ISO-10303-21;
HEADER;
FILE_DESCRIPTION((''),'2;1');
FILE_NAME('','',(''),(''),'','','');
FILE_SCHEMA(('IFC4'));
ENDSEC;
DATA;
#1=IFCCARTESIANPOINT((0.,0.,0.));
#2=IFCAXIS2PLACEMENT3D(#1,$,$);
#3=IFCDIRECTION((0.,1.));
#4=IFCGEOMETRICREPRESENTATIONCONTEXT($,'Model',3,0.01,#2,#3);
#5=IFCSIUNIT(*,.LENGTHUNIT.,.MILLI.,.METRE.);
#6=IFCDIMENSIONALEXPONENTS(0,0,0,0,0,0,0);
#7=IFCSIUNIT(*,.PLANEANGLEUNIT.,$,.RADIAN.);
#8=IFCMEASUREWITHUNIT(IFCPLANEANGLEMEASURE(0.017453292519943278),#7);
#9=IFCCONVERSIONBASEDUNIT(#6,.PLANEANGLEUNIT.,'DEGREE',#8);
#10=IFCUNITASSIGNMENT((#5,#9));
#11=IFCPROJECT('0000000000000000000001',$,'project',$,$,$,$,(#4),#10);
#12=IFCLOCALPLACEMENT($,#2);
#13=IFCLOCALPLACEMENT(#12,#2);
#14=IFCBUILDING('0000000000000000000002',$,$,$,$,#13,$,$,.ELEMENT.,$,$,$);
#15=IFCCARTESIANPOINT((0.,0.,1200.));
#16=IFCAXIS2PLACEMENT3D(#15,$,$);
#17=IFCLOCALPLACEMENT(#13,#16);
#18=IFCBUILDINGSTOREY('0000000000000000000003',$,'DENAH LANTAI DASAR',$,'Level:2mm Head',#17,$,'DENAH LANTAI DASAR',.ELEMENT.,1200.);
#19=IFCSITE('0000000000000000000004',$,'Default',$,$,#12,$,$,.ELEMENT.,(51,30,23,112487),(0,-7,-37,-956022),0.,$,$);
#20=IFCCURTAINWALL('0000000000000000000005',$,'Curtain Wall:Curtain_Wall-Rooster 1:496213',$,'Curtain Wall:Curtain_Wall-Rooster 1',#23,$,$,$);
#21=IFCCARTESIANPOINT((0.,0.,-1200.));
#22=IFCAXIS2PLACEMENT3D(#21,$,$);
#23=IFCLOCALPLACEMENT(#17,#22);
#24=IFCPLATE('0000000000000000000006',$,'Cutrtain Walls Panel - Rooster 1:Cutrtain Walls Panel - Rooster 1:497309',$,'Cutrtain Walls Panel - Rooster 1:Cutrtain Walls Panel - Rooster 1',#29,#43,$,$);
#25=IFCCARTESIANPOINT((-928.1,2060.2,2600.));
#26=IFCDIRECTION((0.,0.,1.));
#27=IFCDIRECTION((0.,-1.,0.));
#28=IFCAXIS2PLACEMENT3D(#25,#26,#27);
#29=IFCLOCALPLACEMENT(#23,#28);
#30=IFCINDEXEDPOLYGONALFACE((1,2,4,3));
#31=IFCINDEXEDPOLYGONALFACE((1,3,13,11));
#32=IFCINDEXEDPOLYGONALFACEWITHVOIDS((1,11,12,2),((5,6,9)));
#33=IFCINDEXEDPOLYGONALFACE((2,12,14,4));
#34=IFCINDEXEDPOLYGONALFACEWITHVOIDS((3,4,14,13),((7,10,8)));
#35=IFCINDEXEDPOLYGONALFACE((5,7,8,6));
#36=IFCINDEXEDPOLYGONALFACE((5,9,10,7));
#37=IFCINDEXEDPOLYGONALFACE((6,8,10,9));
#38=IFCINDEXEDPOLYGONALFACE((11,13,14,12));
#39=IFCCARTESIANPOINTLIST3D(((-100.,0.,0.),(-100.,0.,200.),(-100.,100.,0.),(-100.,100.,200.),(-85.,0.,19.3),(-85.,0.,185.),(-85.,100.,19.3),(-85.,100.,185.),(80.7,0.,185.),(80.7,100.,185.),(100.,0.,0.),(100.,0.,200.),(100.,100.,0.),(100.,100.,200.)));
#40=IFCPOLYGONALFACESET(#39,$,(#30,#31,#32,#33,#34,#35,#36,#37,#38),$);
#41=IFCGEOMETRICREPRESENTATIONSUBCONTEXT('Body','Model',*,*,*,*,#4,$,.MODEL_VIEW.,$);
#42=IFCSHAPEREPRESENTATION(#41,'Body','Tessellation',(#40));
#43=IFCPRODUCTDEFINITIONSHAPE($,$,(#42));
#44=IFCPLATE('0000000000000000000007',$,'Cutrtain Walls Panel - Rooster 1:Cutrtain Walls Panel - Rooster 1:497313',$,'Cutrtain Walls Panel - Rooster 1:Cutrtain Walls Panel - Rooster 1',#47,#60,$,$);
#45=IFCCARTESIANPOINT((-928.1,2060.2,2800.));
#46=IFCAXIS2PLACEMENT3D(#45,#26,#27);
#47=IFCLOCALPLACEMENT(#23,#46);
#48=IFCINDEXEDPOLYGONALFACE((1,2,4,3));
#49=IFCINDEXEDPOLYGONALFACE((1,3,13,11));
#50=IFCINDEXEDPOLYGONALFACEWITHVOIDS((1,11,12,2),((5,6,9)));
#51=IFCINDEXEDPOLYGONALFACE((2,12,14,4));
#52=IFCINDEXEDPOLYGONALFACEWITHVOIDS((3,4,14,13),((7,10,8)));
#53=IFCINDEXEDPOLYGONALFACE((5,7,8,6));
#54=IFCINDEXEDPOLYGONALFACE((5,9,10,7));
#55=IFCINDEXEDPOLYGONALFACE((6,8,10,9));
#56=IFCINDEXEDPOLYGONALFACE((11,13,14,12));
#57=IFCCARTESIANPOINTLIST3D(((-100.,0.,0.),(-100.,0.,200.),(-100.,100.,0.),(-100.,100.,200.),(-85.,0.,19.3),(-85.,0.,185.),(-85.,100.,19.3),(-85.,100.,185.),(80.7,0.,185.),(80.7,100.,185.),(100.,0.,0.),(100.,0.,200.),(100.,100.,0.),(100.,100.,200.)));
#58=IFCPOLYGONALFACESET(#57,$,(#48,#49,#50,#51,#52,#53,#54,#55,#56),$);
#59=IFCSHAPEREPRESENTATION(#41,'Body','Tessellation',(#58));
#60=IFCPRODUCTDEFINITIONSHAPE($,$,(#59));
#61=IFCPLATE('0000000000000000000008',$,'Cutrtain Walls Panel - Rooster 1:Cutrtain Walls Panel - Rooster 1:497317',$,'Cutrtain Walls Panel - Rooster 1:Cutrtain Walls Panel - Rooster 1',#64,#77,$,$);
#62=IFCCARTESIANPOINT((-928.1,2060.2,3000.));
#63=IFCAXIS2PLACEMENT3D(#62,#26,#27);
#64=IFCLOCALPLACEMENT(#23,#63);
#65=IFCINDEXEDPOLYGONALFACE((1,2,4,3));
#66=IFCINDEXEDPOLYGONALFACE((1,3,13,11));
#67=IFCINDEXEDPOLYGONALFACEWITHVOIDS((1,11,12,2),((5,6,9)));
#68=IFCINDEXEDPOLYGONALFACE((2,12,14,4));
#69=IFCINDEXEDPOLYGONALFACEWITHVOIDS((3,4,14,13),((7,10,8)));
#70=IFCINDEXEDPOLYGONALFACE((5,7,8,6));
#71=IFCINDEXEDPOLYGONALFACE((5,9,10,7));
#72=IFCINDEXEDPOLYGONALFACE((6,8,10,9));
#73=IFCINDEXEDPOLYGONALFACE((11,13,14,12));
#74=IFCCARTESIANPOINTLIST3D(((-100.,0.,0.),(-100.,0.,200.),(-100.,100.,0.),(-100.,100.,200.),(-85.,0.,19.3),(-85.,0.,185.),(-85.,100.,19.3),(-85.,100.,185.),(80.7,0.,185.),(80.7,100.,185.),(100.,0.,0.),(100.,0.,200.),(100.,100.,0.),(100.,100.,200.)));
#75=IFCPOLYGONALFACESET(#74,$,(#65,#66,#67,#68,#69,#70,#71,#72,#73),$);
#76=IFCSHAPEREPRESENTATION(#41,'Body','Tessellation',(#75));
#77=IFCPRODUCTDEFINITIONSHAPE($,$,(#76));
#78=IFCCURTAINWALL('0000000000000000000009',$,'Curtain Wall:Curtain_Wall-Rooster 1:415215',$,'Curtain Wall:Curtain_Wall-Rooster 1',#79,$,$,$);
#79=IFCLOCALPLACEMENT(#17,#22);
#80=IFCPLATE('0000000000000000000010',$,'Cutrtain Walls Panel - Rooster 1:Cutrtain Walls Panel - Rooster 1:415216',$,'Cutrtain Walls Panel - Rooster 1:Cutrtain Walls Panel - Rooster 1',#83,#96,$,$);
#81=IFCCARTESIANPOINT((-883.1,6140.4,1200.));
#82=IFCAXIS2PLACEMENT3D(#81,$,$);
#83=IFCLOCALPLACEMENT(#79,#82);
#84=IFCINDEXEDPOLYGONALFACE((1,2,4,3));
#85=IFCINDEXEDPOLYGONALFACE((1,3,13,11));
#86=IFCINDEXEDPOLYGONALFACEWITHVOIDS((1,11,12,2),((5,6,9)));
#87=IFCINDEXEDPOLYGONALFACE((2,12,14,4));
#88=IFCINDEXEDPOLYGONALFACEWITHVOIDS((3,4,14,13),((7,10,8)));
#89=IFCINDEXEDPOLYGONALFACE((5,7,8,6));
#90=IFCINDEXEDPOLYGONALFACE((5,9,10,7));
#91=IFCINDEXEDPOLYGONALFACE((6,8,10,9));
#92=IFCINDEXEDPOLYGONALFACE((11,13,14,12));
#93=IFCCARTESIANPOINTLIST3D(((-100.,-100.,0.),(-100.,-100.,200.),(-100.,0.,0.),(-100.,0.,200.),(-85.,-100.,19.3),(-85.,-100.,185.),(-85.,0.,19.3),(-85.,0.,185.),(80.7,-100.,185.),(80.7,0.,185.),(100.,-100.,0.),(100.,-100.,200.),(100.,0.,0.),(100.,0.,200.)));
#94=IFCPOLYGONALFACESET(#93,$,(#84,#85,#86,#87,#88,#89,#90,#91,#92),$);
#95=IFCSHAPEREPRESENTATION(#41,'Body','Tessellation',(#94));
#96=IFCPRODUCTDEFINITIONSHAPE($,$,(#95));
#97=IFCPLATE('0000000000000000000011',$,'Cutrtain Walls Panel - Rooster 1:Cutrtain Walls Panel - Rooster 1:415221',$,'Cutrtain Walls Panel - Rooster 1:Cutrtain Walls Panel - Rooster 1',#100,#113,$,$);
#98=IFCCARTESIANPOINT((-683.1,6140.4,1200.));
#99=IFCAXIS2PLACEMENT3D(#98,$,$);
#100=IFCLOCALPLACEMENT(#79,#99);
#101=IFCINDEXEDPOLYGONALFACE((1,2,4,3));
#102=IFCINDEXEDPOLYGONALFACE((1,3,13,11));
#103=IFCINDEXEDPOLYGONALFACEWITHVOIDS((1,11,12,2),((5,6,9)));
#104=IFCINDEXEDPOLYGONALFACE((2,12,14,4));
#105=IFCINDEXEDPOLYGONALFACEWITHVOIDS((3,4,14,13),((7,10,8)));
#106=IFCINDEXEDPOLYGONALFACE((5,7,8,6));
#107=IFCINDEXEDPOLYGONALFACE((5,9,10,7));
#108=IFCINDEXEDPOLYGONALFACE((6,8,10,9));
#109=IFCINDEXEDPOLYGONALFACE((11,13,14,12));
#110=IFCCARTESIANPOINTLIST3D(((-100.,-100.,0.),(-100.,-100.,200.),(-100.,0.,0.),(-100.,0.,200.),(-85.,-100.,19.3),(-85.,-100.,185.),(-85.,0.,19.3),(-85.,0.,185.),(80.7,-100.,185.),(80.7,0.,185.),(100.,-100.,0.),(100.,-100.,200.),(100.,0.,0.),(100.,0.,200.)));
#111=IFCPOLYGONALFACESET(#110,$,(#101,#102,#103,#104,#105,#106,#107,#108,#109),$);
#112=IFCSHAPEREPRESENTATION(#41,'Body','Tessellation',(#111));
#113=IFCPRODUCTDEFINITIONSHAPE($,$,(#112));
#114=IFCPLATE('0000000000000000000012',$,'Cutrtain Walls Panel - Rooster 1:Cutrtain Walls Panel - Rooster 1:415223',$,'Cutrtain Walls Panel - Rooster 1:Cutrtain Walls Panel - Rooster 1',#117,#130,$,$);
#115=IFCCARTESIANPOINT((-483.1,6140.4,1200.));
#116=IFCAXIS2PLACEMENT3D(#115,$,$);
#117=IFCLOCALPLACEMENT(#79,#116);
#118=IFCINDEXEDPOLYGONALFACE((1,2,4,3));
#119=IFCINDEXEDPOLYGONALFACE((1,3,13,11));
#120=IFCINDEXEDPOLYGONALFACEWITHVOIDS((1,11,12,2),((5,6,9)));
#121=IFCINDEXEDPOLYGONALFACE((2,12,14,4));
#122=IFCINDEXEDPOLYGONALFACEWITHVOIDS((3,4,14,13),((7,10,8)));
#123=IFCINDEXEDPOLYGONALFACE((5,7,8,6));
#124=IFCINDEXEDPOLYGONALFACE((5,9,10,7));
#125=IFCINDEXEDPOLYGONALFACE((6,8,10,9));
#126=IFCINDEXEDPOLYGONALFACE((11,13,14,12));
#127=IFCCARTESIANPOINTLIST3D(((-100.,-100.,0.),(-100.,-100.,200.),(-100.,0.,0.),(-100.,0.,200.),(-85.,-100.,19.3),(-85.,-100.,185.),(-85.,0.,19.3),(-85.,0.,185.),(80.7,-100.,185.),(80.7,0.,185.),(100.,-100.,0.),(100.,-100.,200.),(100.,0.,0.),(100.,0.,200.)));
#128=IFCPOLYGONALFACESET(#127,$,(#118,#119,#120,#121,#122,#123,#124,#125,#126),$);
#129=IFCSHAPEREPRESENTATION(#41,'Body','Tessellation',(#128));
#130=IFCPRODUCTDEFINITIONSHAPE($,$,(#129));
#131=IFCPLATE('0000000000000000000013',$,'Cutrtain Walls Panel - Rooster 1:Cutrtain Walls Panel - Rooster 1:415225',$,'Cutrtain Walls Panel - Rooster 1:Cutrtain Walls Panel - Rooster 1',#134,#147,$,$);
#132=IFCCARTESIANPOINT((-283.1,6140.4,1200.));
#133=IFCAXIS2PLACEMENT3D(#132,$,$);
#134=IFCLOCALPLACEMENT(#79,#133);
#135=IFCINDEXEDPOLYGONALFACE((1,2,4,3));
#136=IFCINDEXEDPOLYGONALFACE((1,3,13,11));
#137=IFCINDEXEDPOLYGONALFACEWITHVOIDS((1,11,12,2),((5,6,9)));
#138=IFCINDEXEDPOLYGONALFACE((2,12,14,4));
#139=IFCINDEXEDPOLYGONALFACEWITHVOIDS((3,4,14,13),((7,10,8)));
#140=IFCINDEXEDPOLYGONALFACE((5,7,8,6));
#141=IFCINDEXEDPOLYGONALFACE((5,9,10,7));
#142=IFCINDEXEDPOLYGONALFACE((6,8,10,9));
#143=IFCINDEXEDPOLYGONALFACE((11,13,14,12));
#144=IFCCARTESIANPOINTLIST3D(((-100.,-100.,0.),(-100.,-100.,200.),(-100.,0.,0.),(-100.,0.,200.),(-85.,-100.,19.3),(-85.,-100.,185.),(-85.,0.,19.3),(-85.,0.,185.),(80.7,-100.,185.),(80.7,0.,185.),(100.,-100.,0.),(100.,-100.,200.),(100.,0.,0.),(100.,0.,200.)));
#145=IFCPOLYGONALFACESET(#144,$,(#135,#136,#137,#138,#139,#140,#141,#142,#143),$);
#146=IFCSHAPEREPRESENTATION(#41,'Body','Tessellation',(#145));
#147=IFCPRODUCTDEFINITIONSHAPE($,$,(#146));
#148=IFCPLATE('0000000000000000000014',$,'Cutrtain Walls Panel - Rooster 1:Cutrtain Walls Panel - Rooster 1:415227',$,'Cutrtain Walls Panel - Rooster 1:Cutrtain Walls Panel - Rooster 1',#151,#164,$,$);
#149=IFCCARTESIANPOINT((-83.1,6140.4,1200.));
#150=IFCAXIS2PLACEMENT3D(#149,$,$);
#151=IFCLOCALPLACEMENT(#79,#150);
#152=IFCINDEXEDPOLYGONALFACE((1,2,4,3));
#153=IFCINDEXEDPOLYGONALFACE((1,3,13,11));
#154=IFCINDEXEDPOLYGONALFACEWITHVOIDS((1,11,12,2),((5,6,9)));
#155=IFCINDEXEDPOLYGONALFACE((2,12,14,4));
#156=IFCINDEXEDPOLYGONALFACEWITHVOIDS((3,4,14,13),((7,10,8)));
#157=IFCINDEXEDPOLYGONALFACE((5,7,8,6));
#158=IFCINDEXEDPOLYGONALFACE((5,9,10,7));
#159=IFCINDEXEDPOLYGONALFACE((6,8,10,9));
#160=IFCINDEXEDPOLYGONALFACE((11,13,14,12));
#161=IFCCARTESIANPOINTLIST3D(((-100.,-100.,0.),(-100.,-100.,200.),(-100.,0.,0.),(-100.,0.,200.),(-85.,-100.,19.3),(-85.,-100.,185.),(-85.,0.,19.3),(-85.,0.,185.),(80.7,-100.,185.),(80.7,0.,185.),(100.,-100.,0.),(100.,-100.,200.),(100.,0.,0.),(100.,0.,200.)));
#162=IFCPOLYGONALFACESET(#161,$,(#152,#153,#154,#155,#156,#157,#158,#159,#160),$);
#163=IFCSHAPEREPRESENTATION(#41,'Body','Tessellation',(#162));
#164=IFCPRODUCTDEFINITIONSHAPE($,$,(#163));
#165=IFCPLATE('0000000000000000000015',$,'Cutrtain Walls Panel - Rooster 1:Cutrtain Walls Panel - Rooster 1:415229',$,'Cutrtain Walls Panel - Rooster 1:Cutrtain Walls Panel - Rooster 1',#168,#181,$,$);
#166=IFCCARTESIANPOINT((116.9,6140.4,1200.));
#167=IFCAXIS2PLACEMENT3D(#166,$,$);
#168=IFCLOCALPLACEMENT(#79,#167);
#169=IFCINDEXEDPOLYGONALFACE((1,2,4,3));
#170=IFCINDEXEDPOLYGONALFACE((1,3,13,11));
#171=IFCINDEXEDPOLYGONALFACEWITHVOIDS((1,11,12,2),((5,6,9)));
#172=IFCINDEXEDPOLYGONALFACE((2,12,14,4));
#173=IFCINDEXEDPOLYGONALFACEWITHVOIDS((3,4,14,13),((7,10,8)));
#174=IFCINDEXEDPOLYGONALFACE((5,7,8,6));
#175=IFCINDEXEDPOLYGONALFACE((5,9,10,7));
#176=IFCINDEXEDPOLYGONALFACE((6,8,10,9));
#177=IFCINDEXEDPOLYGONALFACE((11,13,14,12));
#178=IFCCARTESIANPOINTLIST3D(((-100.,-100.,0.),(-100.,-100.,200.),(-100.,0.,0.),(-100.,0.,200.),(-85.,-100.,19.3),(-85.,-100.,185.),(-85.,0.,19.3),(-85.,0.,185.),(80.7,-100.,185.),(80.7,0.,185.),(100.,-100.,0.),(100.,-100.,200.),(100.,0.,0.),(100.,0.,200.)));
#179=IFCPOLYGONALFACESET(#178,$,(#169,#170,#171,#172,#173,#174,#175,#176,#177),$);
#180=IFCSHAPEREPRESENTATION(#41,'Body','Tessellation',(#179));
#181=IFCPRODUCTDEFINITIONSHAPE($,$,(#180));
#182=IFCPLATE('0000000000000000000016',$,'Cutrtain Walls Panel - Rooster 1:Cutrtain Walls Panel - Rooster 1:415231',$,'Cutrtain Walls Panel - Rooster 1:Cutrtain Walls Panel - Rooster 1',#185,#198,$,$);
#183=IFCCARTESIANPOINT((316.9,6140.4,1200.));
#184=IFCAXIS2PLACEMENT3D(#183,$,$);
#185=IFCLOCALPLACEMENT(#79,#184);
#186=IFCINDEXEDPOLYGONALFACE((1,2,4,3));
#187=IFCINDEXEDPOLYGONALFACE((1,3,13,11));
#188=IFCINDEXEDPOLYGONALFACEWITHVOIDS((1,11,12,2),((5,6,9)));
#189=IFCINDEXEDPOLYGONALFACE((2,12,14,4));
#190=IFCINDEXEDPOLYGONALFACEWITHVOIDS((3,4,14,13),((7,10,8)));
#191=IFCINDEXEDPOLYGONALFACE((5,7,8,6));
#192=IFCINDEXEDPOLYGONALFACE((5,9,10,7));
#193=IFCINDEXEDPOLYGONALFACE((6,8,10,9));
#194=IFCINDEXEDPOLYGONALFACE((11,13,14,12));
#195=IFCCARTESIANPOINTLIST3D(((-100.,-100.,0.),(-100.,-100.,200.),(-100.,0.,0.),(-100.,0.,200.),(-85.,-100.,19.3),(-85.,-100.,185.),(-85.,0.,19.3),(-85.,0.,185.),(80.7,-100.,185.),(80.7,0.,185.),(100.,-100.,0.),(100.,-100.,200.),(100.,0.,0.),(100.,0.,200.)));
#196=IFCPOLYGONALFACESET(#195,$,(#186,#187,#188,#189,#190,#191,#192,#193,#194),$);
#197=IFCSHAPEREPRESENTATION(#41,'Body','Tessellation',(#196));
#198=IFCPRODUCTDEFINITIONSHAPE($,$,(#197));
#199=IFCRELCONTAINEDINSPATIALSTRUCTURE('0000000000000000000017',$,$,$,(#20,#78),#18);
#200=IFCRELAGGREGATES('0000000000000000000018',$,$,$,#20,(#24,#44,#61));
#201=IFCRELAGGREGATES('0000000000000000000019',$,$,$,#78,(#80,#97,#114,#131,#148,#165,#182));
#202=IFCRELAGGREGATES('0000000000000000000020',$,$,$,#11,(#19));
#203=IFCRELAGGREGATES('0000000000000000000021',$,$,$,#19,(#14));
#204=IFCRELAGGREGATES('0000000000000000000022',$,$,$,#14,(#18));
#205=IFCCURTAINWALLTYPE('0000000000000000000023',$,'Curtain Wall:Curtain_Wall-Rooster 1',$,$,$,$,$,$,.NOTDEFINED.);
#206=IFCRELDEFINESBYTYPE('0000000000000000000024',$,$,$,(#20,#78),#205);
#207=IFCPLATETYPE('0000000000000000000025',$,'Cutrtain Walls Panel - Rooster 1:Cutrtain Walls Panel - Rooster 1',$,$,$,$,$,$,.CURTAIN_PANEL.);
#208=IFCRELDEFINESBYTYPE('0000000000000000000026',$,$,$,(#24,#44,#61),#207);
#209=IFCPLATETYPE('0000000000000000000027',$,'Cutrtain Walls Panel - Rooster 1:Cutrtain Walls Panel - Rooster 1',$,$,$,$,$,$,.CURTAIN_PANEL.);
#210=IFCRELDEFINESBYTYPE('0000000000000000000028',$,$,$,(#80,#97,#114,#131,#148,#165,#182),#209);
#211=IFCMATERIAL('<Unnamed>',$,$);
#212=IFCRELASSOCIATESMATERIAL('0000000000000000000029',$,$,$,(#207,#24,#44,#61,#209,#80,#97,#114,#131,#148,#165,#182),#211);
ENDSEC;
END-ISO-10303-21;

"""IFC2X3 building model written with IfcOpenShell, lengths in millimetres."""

from ifc_helpers import new_model, entity, si_unit, converted_unit, direction, frame, origin, place, context, subcontext, project, spatial, polyline, outline, extrude, source, transform, mapped, material, type_object, type_shapes, element, aggregate, save


model = new_model("IFC2X3")

# Units and contexts
model_context = context("Model", 3, precision=0.01, world=origin(), true_north=direction((0.0, 1.0)))
body_context = subcontext(model_context, "Body", "Model", "MODEL_VIEW")
ifc_project = project(units=[si_unit("LENGTHUNIT", "METRE", prefix="MILLI"), converted_unit("PLANEANGLEUNIT", "DEGREE", entity("IfcPlaneAngleMeasure", 0.017453292519943278), si_unit("PLANEANGLEUNIT", "RADIAN"), dimensions=[0, 0, 0, 0, 0, 0, 0])], contexts=[model_context])

# Site, building, storey
site_placement = place(None, origin())
site = spatial("IfcSite", under=ifc_project, at=site_placement, Name="Default", CompositionType="ELEMENT", RefLatitude=(51, 30, 23, 112487), RefLongitude=(0, -7, -37, -956022), RefElevation=0.0)
building_placement = place(site_placement, origin())
building = spatial("IfcBuilding", under=site, at=building_placement, CompositionType="ELEMENT")
storey_placement = place(building_placement, frame((0.0, 0.0, 1200.0)))
storey = spatial("IfcBuildingStorey", under=building, at=storey_placement, Name="DENAH LANTAI DASAR", ObjectType="Level:2mm Head", LongName="DENAH LANTAI DASAR", CompositionType="ELEMENT", Elevation=1200.0)

# Curtain walls, plates
curtain_wall_type = type_object("IfcCurtainWallType", Name="Curtain Wall:Curtain_Wall-Rooster 1", PredefinedType="NOTDEFINED")
curtain_wall_1_placement = place(storey_placement, frame((0.0, 0.0, -1200.0)))
curtain_wall_1 = element("IfcCurtainWall", 1, at=curtain_wall_1_placement, inside=storey, type_object=curtain_wall_type, Name="Curtain Wall:Curtain_Wall-Rooster 1:496213", ObjectType="Curtain Wall:Curtain_Wall-Rooster 1")
ifc_material_1 = material(Name="<Unnamed>")
plate_type_1 = type_object("IfcPlateType", Name="Cutrtain Walls Panel - Rooster 1:Cutrtain Walls Panel - Rooster 1", PredefinedType="CURTAIN_PANEL", material=ifc_material_1)
shared_shape_1 = source(origin(), body_context, "Body", "SweptSolid", [
    extrude(outline(polyline([(-100.0, -100.0), (100.0, -100.0), (100.0, 100.0), (-100.0, 100.0), (-100.0, -100.0)]), holes=[polyline([(80.7, 85.0), (-85.0, -80.7), (-85.0, 85.0), (80.7, 85.0)])]), frame((0.0, 0.0, 100.0), z_axis=(0.0, 1.0, 0.0), x_axis=(0.0, 0.0, -1.0)), (0.0, 0.0, 1.0), 100.0),
])
type_shapes(plate_type_1, [shared_shape_1])
plate_1_placement = place(curtain_wall_1_placement, frame((-928.1, 2060.2, 2600.0), z_axis=(0.0, 0.0, 1.0), x_axis=(0.0, -1.0, 0.0)))
plate_1 = element("IfcPlate", 2, at=plate_1_placement, type_object=plate_type_1, material=ifc_material_1, Name="Cutrtain Walls Panel - Rooster 1:Cutrtain Walls Panel - Rooster 1:497309", ObjectType="Cutrtain Walls Panel - Rooster 1:Cutrtain Walls Panel - Rooster 1", context=body_context, shape_type="MappedRepresentation", body=[
    mapped(shared_shape_1, transform((0.0, 0.0, 0.0), scale=1.0)),
])
plate_2_placement = place(curtain_wall_1_placement, frame((-928.1, 2060.2, 2800.0), z_axis=(0.0, 0.0, 1.0), x_axis=(0.0, -1.0, 0.0)))
plate_2 = element("IfcPlate", 3, at=plate_2_placement, type_object=plate_type_1, material=ifc_material_1, Name="Cutrtain Walls Panel - Rooster 1:Cutrtain Walls Panel - Rooster 1:497313", ObjectType="Cutrtain Walls Panel - Rooster 1:Cutrtain Walls Panel - Rooster 1", context=body_context, shape_type="MappedRepresentation", body=[
    mapped(shared_shape_1, transform((0.0, 0.0, 0.0), scale=1.0)),
])
plate_3_placement = place(curtain_wall_1_placement, frame((-928.1, 2060.2, 3000.0), z_axis=(0.0, 0.0, 1.0), x_axis=(0.0, -1.0, 0.0)))
plate_3 = element("IfcPlate", 4, at=plate_3_placement, type_object=plate_type_1, material=ifc_material_1, Name="Cutrtain Walls Panel - Rooster 1:Cutrtain Walls Panel - Rooster 1:497317", ObjectType="Cutrtain Walls Panel - Rooster 1:Cutrtain Walls Panel - Rooster 1", context=body_context, shape_type="MappedRepresentation", body=[
    mapped(shared_shape_1, transform((0.0, 0.0, 0.0), scale=1.0)),
])
aggregate(curtain_wall_1, [plate_1, plate_2, plate_3])
curtain_wall_2_placement = place(storey_placement, frame((0.0, 0.0, -1200.0)))
curtain_wall_2 = element("IfcCurtainWall", 5, at=curtain_wall_2_placement, inside=storey, type_object=curtain_wall_type, Name="Curtain Wall:Curtain_Wall-Rooster 1:415215", ObjectType="Curtain Wall:Curtain_Wall-Rooster 1")
plate_type_2 = type_object("IfcPlateType", Name="Cutrtain Walls Panel - Rooster 1:Cutrtain Walls Panel - Rooster 1", PredefinedType="CURTAIN_PANEL", material=ifc_material_1)
shared_shape_2 = source(origin(), body_context, "Body", "SweptSolid", [
    extrude(outline(polyline([(-100.0, -100.0), (100.0, -100.0), (100.0, 100.0), (-100.0, 100.0), (-100.0, -100.0)]), holes=[polyline([(80.7, 85.0), (-85.0, -80.7), (-85.0, 85.0), (80.7, 85.0)])]), frame((0.0, -100.0, 100.0), z_axis=(0.0, 1.0, 0.0), x_axis=(0.0, 0.0, -1.0)), (0.0, 0.0, 1.0), 100.0),
])
type_shapes(plate_type_2, [shared_shape_2])
plate_4_placement = place(curtain_wall_2_placement, frame((-883.1, 6140.4, 1200.0)))
plate_4 = element("IfcPlate", 6, at=plate_4_placement, type_object=plate_type_2, material=ifc_material_1, Name="Cutrtain Walls Panel - Rooster 1:Cutrtain Walls Panel - Rooster 1:415216", ObjectType="Cutrtain Walls Panel - Rooster 1:Cutrtain Walls Panel - Rooster 1", context=body_context, shape_type="MappedRepresentation", body=[
    mapped(shared_shape_2, transform((0.0, 0.0, 0.0), scale=1.0)),
])
plate_5_placement = place(curtain_wall_2_placement, frame((-683.1, 6140.4, 1200.0)))
plate_5 = element("IfcPlate", 7, at=plate_5_placement, type_object=plate_type_2, material=ifc_material_1, Name="Cutrtain Walls Panel - Rooster 1:Cutrtain Walls Panel - Rooster 1:415221", ObjectType="Cutrtain Walls Panel - Rooster 1:Cutrtain Walls Panel - Rooster 1", context=body_context, shape_type="MappedRepresentation", body=[
    mapped(shared_shape_2, transform((0.0, 0.0, 0.0), scale=1.0)),
])
plate_6_placement = place(curtain_wall_2_placement, frame((-483.1, 6140.4, 1200.0)))
plate_6 = element("IfcPlate", 8, at=plate_6_placement, type_object=plate_type_2, material=ifc_material_1, Name="Cutrtain Walls Panel - Rooster 1:Cutrtain Walls Panel - Rooster 1:415223", ObjectType="Cutrtain Walls Panel - Rooster 1:Cutrtain Walls Panel - Rooster 1", context=body_context, shape_type="MappedRepresentation", body=[
    mapped(shared_shape_2, transform((0.0, 0.0, 0.0), scale=1.0)),
])
plate_7_placement = place(curtain_wall_2_placement, frame((-283.1, 6140.4, 1200.0)))
plate_7 = element("IfcPlate", 9, at=plate_7_placement, type_object=plate_type_2, material=ifc_material_1, Name="Cutrtain Walls Panel - Rooster 1:Cutrtain Walls Panel - Rooster 1:415225", ObjectType="Cutrtain Walls Panel - Rooster 1:Cutrtain Walls Panel - Rooster 1", context=body_context, shape_type="MappedRepresentation", body=[
    mapped(shared_shape_2, transform((0.0, 0.0, 0.0), scale=1.0)),
])
plate_8_placement = place(curtain_wall_2_placement, frame((-83.1, 6140.4, 1200.0)))
plate_8 = element("IfcPlate", 10, at=plate_8_placement, type_object=plate_type_2, material=ifc_material_1, Name="Cutrtain Walls Panel - Rooster 1:Cutrtain Walls Panel - Rooster 1:415227", ObjectType="Cutrtain Walls Panel - Rooster 1:Cutrtain Walls Panel - Rooster 1", context=body_context, shape_type="MappedRepresentation", body=[
    mapped(shared_shape_2, transform((0.0, 0.0, 0.0), scale=1.0)),
])
plate_9_placement = place(curtain_wall_2_placement, frame((116.9, 6140.4, 1200.0)))
plate_9 = element("IfcPlate", 11, at=plate_9_placement, type_object=plate_type_2, material=ifc_material_1, Name="Cutrtain Walls Panel - Rooster 1:Cutrtain Walls Panel - Rooster 1:415229", ObjectType="Cutrtain Walls Panel - Rooster 1:Cutrtain Walls Panel - Rooster 1", context=body_context, shape_type="MappedRepresentation", body=[
    mapped(shared_shape_2, transform((0.0, 0.0, 0.0), scale=1.0)),
])
plate_10_placement = place(curtain_wall_2_placement, frame((316.9, 6140.4, 1200.0)))
plate_10 = element("IfcPlate", 12, at=plate_10_placement, type_object=plate_type_2, material=ifc_material_1, Name="Cutrtain Walls Panel - Rooster 1:Cutrtain Walls Panel - Rooster 1:415231", ObjectType="Cutrtain Walls Panel - Rooster 1:Cutrtain Walls Panel - Rooster 1", context=body_context, shape_type="MappedRepresentation", body=[
    mapped(shared_shape_2, transform((0.0, 0.0, 0.0), scale=1.0)),
])
aggregate(curtain_wall_2, [plate_4, plate_5, plate_6, plate_7, plate_8, plate_9, plate_10])

save(model, "model.ifc")
